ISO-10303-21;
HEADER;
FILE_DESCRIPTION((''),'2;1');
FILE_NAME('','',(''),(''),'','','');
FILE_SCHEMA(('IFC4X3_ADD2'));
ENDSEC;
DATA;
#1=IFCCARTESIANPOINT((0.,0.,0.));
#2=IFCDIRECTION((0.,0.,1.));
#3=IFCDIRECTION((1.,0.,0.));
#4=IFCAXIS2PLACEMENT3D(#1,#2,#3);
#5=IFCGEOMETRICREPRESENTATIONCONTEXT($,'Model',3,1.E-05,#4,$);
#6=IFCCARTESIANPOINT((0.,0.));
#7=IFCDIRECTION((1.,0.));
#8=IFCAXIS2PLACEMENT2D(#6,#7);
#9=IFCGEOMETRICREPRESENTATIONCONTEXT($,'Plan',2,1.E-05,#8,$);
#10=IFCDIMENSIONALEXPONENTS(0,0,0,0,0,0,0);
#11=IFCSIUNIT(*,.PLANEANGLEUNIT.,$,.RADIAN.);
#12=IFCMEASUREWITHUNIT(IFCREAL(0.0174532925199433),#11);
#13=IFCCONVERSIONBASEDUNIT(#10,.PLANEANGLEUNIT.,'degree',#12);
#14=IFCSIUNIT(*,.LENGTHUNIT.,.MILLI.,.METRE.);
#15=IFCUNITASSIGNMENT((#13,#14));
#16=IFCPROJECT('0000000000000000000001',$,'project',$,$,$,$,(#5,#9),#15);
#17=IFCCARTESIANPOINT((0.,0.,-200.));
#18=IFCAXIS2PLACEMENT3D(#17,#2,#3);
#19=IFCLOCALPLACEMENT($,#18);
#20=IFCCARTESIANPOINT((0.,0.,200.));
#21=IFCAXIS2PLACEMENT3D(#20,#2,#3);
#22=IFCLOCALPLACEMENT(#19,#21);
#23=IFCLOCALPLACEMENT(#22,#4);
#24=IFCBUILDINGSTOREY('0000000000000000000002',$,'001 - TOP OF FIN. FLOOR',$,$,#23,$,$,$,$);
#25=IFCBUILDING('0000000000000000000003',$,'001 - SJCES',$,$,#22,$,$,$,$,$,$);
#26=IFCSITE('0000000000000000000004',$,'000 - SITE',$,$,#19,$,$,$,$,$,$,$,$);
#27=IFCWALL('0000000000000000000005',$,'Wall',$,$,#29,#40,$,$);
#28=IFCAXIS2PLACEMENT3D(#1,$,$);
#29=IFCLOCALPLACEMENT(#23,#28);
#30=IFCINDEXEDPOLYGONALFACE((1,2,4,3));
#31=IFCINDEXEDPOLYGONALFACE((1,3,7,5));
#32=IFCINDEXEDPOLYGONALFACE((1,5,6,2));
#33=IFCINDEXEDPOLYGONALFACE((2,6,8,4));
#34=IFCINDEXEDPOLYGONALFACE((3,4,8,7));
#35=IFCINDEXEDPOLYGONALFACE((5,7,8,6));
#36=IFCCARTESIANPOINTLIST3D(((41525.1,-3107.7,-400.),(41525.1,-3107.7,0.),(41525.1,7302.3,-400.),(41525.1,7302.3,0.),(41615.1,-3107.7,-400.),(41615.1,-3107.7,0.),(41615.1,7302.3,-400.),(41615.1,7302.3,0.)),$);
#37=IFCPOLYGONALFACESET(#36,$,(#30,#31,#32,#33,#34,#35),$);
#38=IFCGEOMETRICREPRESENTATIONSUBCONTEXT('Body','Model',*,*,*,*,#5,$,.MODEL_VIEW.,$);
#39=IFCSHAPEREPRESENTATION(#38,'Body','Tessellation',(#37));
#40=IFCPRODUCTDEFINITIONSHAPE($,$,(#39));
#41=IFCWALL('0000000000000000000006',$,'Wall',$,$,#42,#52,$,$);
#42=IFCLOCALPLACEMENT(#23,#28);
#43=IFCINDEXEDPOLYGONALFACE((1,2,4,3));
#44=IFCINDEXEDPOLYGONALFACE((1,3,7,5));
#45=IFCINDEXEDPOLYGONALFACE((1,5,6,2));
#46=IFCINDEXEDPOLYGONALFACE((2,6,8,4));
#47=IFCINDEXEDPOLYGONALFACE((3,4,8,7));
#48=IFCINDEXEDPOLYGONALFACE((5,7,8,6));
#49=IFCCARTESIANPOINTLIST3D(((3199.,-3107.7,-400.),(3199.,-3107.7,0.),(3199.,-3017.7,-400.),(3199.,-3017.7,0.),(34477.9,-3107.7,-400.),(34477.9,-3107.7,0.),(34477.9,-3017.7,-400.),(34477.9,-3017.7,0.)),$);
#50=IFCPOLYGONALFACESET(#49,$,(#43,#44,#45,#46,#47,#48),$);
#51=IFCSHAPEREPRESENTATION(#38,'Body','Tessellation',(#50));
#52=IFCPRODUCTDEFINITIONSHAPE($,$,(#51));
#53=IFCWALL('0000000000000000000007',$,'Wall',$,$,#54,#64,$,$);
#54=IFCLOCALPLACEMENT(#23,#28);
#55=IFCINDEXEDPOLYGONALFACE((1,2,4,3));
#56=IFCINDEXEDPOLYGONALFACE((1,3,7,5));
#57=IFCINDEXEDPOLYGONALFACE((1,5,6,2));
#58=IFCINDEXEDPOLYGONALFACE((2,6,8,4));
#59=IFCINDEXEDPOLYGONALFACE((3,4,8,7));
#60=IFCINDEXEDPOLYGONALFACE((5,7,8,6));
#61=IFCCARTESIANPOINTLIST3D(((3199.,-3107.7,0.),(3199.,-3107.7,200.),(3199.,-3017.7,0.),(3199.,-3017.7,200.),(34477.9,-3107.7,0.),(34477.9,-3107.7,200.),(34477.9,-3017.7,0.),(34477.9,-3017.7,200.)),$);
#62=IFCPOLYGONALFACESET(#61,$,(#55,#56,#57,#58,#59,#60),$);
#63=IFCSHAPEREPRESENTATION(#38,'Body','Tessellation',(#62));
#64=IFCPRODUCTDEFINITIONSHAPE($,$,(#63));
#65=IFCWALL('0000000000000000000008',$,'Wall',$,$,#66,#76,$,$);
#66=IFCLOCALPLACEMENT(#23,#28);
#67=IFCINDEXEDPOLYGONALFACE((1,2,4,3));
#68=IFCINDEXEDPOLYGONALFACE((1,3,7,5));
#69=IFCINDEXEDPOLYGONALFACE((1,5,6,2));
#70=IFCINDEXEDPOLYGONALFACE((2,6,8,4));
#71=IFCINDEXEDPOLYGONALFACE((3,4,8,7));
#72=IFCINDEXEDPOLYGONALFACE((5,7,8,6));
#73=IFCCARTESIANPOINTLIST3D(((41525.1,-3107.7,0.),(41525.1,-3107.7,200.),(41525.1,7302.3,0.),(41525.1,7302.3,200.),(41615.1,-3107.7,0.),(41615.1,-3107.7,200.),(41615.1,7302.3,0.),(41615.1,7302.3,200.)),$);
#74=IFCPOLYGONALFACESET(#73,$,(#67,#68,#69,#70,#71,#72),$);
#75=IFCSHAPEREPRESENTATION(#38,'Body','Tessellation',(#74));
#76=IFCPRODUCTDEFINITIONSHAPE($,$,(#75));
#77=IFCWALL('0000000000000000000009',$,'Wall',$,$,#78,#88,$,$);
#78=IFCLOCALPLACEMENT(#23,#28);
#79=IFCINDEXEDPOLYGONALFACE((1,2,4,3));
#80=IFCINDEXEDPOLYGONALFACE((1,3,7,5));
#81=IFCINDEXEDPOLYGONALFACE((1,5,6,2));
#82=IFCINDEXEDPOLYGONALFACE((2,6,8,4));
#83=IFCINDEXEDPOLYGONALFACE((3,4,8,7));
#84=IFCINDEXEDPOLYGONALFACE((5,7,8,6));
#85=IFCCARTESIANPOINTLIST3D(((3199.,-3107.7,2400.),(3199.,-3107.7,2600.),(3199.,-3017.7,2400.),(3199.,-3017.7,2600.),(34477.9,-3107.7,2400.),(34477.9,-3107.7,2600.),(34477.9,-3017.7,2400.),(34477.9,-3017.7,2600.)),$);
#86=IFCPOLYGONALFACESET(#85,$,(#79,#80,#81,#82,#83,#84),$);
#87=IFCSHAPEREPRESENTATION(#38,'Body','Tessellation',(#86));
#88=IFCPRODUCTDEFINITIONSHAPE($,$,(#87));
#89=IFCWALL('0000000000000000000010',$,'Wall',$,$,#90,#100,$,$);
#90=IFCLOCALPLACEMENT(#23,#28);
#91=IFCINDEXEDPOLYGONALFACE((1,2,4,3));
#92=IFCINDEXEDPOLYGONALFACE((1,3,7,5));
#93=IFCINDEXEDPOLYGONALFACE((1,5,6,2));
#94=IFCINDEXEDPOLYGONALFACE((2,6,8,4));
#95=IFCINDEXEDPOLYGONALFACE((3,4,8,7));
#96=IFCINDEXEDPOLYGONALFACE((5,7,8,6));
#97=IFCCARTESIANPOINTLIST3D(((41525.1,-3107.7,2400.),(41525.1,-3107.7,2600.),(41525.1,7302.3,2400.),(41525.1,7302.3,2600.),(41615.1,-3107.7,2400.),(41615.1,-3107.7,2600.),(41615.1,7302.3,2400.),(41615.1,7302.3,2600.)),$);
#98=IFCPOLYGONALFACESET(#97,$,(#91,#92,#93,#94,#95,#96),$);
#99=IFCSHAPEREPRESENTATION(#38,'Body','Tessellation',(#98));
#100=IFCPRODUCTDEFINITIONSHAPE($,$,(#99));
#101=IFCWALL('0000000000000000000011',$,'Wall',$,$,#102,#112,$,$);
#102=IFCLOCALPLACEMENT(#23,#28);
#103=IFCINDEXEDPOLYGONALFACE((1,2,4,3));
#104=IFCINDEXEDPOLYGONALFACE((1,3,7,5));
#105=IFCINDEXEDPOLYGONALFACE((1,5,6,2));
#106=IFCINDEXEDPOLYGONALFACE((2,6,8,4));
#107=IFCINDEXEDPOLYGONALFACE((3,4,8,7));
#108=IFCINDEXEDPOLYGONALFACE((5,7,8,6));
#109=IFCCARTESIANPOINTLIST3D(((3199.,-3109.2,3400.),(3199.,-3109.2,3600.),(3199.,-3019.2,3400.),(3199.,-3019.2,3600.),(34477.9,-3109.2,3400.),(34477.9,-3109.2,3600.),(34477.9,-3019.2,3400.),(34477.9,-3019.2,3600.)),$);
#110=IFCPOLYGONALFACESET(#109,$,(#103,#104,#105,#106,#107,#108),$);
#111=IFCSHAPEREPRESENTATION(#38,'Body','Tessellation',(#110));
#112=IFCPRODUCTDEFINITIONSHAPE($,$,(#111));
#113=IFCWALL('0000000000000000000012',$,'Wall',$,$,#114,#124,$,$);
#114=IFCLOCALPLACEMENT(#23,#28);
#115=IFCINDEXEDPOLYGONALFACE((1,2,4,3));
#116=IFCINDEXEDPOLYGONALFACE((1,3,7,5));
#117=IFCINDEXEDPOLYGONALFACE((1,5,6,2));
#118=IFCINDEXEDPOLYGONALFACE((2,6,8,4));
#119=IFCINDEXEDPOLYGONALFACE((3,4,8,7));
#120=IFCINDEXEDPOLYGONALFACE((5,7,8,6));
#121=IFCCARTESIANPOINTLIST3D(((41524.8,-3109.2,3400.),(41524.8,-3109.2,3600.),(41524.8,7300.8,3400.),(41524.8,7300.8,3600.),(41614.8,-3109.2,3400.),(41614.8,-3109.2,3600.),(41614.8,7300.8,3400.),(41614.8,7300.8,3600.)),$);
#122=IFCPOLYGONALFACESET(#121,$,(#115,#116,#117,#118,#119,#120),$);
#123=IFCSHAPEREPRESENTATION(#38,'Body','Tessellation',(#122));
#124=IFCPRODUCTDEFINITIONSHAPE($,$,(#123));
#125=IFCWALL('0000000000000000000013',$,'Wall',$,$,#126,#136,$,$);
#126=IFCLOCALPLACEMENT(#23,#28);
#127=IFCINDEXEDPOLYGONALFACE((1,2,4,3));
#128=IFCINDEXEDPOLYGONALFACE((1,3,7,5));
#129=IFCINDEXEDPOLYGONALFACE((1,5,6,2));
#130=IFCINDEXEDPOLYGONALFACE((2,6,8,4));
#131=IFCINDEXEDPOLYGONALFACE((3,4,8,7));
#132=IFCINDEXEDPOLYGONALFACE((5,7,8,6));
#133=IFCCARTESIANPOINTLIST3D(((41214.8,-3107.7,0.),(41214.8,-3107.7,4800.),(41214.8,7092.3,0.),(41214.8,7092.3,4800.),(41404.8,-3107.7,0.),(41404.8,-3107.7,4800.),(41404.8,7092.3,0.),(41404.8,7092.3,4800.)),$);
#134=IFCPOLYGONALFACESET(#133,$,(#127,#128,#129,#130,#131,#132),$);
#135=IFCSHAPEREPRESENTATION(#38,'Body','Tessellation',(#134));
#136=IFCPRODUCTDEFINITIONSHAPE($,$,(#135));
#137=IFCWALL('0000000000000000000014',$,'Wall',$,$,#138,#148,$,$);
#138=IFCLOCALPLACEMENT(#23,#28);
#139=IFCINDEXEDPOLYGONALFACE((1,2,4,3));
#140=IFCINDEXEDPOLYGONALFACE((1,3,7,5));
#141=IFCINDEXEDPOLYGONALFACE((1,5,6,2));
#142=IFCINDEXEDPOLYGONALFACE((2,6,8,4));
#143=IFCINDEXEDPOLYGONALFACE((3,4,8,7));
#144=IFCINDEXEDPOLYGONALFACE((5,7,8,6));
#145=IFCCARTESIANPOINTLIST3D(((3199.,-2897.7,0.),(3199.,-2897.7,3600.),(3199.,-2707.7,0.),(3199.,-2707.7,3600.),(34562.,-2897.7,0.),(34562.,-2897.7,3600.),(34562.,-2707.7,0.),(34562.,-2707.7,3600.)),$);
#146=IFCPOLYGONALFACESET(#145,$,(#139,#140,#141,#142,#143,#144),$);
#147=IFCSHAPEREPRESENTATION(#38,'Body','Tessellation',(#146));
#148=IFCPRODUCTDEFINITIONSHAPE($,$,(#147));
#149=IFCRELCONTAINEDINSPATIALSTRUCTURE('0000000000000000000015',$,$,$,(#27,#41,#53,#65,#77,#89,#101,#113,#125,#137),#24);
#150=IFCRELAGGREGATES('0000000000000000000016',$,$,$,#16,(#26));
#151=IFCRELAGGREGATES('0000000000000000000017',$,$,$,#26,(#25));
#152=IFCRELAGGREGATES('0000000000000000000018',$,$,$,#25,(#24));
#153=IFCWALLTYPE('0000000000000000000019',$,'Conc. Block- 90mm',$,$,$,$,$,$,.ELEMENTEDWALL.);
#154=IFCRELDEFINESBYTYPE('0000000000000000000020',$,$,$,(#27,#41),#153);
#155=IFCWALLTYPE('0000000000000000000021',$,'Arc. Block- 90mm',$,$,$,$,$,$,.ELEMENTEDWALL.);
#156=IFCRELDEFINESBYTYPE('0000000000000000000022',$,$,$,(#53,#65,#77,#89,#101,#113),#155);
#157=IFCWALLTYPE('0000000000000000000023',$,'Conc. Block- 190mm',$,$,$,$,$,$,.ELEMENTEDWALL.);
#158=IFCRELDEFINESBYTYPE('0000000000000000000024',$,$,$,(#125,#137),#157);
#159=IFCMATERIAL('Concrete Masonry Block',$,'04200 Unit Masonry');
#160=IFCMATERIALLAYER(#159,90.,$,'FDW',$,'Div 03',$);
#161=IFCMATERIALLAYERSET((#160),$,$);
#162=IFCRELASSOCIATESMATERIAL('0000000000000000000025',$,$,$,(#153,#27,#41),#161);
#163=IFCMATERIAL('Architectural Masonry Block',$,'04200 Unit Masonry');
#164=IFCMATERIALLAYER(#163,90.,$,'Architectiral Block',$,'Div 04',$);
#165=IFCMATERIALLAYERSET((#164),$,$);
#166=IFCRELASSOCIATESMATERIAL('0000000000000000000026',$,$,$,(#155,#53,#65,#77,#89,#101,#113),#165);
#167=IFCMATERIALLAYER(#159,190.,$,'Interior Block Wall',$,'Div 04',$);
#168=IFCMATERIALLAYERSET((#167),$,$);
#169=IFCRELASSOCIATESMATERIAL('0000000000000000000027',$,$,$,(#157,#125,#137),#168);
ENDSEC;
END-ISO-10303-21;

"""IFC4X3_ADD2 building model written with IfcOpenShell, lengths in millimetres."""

from ifc_helpers import new_model, entity, si_unit, converted_unit, frame, origin_with_axes, origin_2d_with_axis, place, context, subcontext, project, spatial, indexed_curve, outline, extrude, material, layer, layer_set, layer_usage, type_object, element, save


model = new_model("IFC4X3_ADD2")

# Units and contexts
model_context = context("Model", 3, precision=1e-05, world=origin_with_axes())
plan_context = context("Plan", 2, precision=1e-05, world=origin_2d_with_axis())
body_context_1 = subcontext(model_context, "Body", "Model", "MODEL_VIEW")
ifc_project = project(units=[converted_unit("PLANEANGLEUNIT", "degree", entity("IfcReal", 0.0174532925199433), si_unit("PLANEANGLEUNIT", "RADIAN"), dimensions=[0, 0, 0, 0, 0, 0, 0]), si_unit("LENGTHUNIT", "METRE", prefix="MILLI")], contexts=[model_context, plan_context])

# Site, building, storey
site_placement = place(None, frame((0.0, 0.0, -200.0), z_axis=(0.0, 0.0, 1.0), x_axis=(1.0, 0.0, 0.0)))
site = spatial("IfcSite", under=ifc_project, at=site_placement, Name="000 - SITE")
building_placement = place(site_placement, frame((0.0, 0.0, 200.0), z_axis=(0.0, 0.0, 1.0), x_axis=(1.0, 0.0, 0.0)))
building = spatial("IfcBuilding", under=site, at=building_placement, Name="001 - SJCES")
storey_placement = place(building_placement, origin_with_axes())
storey = spatial("IfcBuildingStorey", under=building, at=storey_placement, Name="001 - TOP OF FIN. FLOOR")

# Walls
ifc_material_1 = material(Name="Concrete Masonry Block", Category="04200 Unit Masonry")
ifc_layer_1 = layer(ifc_material_1, 90.0, Name="FDW", Category="Div 03")
ifc_layer_set_1 = layer_set([ifc_layer_1])
ifc_layer_usage_1 = layer_usage(ifc_layer_set_1, "AXIS2", "POSITIVE", 0.0)
wall_type_1 = type_object("IfcWallType", Name="Conc. Block- 90mm", PredefinedType="ELEMENTEDWALL", material=ifc_layer_set_1)
wall_1_placement = place(storey_placement, frame((41525.1, 7302.3, -400.0), z_axis=(0.0, 0.0, 1.0), x_axis=(0.0, -1.0, 0.0)))
element("IfcWall", 1, at=wall_1_placement, inside=storey, type_object=wall_type_1, material=ifc_layer_usage_1, Name="Wall", context=body_context_1, shape_type="SweptSolid", body=[
    extrude(outline(indexed_curve([(0.0, 0.0), (0.0, 90.0), (10410.0, 90.0), (10410.0, 0.0), (0.0, 0.0)], self_intersect=False)), origin_with_axes(), (0.0, 0.0, 1.0), 400.0),
])
ifc_layer_usage_2 = layer_usage(ifc_layer_set_1, "AXIS2", "POSITIVE", 0.0)
wall_2_placement = place(storey_placement, frame((3199.0, -3107.7, -400.0), z_axis=(0.0, 0.0, 1.0), x_axis=(1.0, 0.0, 0.0)))
element("IfcWall", 2, at=wall_2_placement, inside=storey, type_object=wall_type_1, material=ifc_layer_usage_2, Name="Wall", context=body_context_1, shape_type="SweptSolid", body=[
    extrude(outline(indexed_curve([(0.0, 0.0), (0.0, 90.0), (31278.9, 90.0), (31278.9, 0.0), (0.0, 0.0)], self_intersect=False)), origin_with_axes(), (0.0, 0.0, 1.0), 400.0),
])
ifc_material_2 = material(Name="Architectural Masonry Block", Category="04200 Unit Masonry")
ifc_layer_2 = layer(ifc_material_2, 90.0, Name="Architectiral Block", Category="Div 04")
ifc_layer_set_2 = layer_set([ifc_layer_2])
ifc_layer_usage_3 = layer_usage(ifc_layer_set_2, "AXIS2", "POSITIVE", 0.0)
wall_type_2 = type_object("IfcWallType", Name="Arc. Block- 90mm", PredefinedType="ELEMENTEDWALL", material=ifc_layer_set_2)
wall_3_placement = place(storey_placement, frame((3199.0, -3107.7, 0.0), z_axis=(0.0, 0.0, 1.0), x_axis=(1.0, 0.0, 0.0)))
element("IfcWall", 3, at=wall_3_placement, inside=storey, type_object=wall_type_2, material=ifc_layer_usage_3, Name="Wall", context=body_context_1, shape_type="SweptSolid", body=[
    extrude(outline(indexed_curve([(0.0, 0.0), (0.0, 90.0), (31278.9, 90.0), (31278.9, 0.0), (0.0, 0.0)], self_intersect=False)), origin_with_axes(), (0.0, 0.0, 1.0), 200.0),
])
ifc_layer_usage_4 = layer_usage(ifc_layer_set_2, "AXIS2", "POSITIVE", 0.0)
wall_4_placement = place(storey_placement, frame((41615.1, -3107.7, 0.0), z_axis=(0.0, 0.0, 1.0), x_axis=(0.0, 1.0, 0.0)))
element("IfcWall", 4, at=wall_4_placement, inside=storey, type_object=wall_type_2, material=ifc_layer_usage_4, Name="Wall", context=body_context_1, shape_type="SweptSolid", body=[
    extrude(outline(indexed_curve([(0.0, 0.0), (0.0, 90.0), (10410.0, 90.0), (10410.0, 0.0), (0.0, 0.0)], self_intersect=False)), origin_with_axes(), (0.0, 0.0, 1.0), 200.0),
])
ifc_layer_usage_5 = layer_usage(ifc_layer_set_2, "AXIS2", "POSITIVE", 0.0)
wall_5_placement = place(storey_placement, frame((3199.0, -3107.7, 2400.0), z_axis=(0.0, 0.0, 1.0), x_axis=(1.0, 0.0, 0.0)))
element("IfcWall", 5, at=wall_5_placement, inside=storey, type_object=wall_type_2, material=ifc_layer_usage_5, Name="Wall", context=body_context_1, shape_type="SweptSolid", body=[
    extrude(outline(indexed_curve([(0.0, 0.0), (0.0, 90.0), (31278.9, 90.0), (31278.9, 0.0), (0.0, 0.0)], self_intersect=False)), origin_with_axes(), (0.0, 0.0, 1.0), 200.0),
])
ifc_layer_usage_6 = layer_usage(ifc_layer_set_2, "AXIS2", "POSITIVE", 0.0)
wall_6_placement = place(storey_placement, frame((41615.1, -3107.7, 2400.0), z_axis=(0.0, 0.0, 1.0), x_axis=(0.0, 1.0, 0.0)))
element("IfcWall", 6, at=wall_6_placement, inside=storey, type_object=wall_type_2, material=ifc_layer_usage_6, Name="Wall", context=body_context_1, shape_type="SweptSolid", body=[
    extrude(outline(indexed_curve([(0.0, 0.0), (0.0, 90.0), (10410.0, 90.0), (10410.0, 0.0), (0.0, 0.0)], self_intersect=False)), origin_with_axes(), (0.0, 0.0, 1.0), 200.0),
])
ifc_layer_usage_7 = layer_usage(ifc_layer_set_2, "AXIS2", "POSITIVE", 0.0)
wall_7_placement = place(storey_placement, frame((3199.0, -3109.2, 3400.0), z_axis=(0.0, 0.0, 1.0), x_axis=(1.0, 0.0, 0.0)))
element("IfcWall", 7, at=wall_7_placement, inside=storey, type_object=wall_type_2, material=ifc_layer_usage_7, Name="Wall", context=body_context_1, shape_type="SweptSolid", body=[
    extrude(outline(indexed_curve([(0.0, 0.0), (0.0, 90.0), (31278.9, 90.0), (31278.9, 0.0), (0.0, 0.0)], self_intersect=False)), origin_with_axes(), (0.0, 0.0, 1.0), 200.0),
])
ifc_layer_usage_8 = layer_usage(ifc_layer_set_2, "AXIS2", "POSITIVE", 0.0)
wall_8_placement = place(storey_placement, frame((41614.8, -3109.2, 3400.0), z_axis=(0.0, 0.0, 1.0), x_axis=(0.0, 1.0, 0.0)))
element("IfcWall", 8, at=wall_8_placement, inside=storey, type_object=wall_type_2, material=ifc_layer_usage_8, Name="Wall", context=body_context_1, shape_type="SweptSolid", body=[
    extrude(outline(indexed_curve([(0.0, 0.0), (0.0, 90.0), (10410.0, 90.0), (10410.0, 0.0), (0.0, 0.0)], self_intersect=False)), origin_with_axes(), (0.0, 0.0, 1.0), 200.0),
])
ifc_layer_3 = layer(ifc_material_1, 190.0, Name="Interior Block Wall", Category="Div 04")
ifc_layer_set_3 = layer_set([ifc_layer_3])
ifc_layer_usage_9 = layer_usage(ifc_layer_set_3, "AXIS2", "POSITIVE", 0.0)
wall_type_3 = type_object("IfcWallType", Name="Conc. Block- 190mm", PredefinedType="ELEMENTEDWALL", material=ifc_layer_set_3)
wall_9_placement = place(storey_placement, frame((41214.8, 7092.3, 0.0), z_axis=(0.0, 0.0, 1.0), x_axis=(0.0, -1.0, 0.0)))
element("IfcWall", 9, at=wall_9_placement, inside=storey, type_object=wall_type_3, material=ifc_layer_usage_9, Name="Wall", context=body_context_1, shape_type="SweptSolid", body=[
    extrude(outline(indexed_curve([(0.0, 0.0), (0.0, 190.0), (10200.0, 190.0), (10200.0, 0.0), (0.0, 0.0)], self_intersect=False)), origin_with_axes(), (0.0, 0.0, 1.0), 4800.0),
])
ifc_layer_usage_10 = layer_usage(ifc_layer_set_3, "AXIS2", "POSITIVE", 0.0)
wall_10_placement = place(storey_placement, frame((34562.0, -2707.7, 0.0), z_axis=(0.0, 0.0, 1.0), x_axis=(-1.0, 0.0, 0.0)))
element("IfcWall", 10, at=wall_10_placement, inside=storey, type_object=wall_type_3, material=ifc_layer_usage_10, Name="Wall", context=body_context_1, shape_type="SweptSolid", body=[
    extrude(outline(indexed_curve([(0.0, 0.0), (0.0, 190.0), (31363.0, 190.0), (31363.0, 0.0), (0.0, 0.0)], self_intersect=False)), origin_with_axes(), (0.0, 0.0, 1.0), 3600.0),
])

save(model, "model.ifc")
